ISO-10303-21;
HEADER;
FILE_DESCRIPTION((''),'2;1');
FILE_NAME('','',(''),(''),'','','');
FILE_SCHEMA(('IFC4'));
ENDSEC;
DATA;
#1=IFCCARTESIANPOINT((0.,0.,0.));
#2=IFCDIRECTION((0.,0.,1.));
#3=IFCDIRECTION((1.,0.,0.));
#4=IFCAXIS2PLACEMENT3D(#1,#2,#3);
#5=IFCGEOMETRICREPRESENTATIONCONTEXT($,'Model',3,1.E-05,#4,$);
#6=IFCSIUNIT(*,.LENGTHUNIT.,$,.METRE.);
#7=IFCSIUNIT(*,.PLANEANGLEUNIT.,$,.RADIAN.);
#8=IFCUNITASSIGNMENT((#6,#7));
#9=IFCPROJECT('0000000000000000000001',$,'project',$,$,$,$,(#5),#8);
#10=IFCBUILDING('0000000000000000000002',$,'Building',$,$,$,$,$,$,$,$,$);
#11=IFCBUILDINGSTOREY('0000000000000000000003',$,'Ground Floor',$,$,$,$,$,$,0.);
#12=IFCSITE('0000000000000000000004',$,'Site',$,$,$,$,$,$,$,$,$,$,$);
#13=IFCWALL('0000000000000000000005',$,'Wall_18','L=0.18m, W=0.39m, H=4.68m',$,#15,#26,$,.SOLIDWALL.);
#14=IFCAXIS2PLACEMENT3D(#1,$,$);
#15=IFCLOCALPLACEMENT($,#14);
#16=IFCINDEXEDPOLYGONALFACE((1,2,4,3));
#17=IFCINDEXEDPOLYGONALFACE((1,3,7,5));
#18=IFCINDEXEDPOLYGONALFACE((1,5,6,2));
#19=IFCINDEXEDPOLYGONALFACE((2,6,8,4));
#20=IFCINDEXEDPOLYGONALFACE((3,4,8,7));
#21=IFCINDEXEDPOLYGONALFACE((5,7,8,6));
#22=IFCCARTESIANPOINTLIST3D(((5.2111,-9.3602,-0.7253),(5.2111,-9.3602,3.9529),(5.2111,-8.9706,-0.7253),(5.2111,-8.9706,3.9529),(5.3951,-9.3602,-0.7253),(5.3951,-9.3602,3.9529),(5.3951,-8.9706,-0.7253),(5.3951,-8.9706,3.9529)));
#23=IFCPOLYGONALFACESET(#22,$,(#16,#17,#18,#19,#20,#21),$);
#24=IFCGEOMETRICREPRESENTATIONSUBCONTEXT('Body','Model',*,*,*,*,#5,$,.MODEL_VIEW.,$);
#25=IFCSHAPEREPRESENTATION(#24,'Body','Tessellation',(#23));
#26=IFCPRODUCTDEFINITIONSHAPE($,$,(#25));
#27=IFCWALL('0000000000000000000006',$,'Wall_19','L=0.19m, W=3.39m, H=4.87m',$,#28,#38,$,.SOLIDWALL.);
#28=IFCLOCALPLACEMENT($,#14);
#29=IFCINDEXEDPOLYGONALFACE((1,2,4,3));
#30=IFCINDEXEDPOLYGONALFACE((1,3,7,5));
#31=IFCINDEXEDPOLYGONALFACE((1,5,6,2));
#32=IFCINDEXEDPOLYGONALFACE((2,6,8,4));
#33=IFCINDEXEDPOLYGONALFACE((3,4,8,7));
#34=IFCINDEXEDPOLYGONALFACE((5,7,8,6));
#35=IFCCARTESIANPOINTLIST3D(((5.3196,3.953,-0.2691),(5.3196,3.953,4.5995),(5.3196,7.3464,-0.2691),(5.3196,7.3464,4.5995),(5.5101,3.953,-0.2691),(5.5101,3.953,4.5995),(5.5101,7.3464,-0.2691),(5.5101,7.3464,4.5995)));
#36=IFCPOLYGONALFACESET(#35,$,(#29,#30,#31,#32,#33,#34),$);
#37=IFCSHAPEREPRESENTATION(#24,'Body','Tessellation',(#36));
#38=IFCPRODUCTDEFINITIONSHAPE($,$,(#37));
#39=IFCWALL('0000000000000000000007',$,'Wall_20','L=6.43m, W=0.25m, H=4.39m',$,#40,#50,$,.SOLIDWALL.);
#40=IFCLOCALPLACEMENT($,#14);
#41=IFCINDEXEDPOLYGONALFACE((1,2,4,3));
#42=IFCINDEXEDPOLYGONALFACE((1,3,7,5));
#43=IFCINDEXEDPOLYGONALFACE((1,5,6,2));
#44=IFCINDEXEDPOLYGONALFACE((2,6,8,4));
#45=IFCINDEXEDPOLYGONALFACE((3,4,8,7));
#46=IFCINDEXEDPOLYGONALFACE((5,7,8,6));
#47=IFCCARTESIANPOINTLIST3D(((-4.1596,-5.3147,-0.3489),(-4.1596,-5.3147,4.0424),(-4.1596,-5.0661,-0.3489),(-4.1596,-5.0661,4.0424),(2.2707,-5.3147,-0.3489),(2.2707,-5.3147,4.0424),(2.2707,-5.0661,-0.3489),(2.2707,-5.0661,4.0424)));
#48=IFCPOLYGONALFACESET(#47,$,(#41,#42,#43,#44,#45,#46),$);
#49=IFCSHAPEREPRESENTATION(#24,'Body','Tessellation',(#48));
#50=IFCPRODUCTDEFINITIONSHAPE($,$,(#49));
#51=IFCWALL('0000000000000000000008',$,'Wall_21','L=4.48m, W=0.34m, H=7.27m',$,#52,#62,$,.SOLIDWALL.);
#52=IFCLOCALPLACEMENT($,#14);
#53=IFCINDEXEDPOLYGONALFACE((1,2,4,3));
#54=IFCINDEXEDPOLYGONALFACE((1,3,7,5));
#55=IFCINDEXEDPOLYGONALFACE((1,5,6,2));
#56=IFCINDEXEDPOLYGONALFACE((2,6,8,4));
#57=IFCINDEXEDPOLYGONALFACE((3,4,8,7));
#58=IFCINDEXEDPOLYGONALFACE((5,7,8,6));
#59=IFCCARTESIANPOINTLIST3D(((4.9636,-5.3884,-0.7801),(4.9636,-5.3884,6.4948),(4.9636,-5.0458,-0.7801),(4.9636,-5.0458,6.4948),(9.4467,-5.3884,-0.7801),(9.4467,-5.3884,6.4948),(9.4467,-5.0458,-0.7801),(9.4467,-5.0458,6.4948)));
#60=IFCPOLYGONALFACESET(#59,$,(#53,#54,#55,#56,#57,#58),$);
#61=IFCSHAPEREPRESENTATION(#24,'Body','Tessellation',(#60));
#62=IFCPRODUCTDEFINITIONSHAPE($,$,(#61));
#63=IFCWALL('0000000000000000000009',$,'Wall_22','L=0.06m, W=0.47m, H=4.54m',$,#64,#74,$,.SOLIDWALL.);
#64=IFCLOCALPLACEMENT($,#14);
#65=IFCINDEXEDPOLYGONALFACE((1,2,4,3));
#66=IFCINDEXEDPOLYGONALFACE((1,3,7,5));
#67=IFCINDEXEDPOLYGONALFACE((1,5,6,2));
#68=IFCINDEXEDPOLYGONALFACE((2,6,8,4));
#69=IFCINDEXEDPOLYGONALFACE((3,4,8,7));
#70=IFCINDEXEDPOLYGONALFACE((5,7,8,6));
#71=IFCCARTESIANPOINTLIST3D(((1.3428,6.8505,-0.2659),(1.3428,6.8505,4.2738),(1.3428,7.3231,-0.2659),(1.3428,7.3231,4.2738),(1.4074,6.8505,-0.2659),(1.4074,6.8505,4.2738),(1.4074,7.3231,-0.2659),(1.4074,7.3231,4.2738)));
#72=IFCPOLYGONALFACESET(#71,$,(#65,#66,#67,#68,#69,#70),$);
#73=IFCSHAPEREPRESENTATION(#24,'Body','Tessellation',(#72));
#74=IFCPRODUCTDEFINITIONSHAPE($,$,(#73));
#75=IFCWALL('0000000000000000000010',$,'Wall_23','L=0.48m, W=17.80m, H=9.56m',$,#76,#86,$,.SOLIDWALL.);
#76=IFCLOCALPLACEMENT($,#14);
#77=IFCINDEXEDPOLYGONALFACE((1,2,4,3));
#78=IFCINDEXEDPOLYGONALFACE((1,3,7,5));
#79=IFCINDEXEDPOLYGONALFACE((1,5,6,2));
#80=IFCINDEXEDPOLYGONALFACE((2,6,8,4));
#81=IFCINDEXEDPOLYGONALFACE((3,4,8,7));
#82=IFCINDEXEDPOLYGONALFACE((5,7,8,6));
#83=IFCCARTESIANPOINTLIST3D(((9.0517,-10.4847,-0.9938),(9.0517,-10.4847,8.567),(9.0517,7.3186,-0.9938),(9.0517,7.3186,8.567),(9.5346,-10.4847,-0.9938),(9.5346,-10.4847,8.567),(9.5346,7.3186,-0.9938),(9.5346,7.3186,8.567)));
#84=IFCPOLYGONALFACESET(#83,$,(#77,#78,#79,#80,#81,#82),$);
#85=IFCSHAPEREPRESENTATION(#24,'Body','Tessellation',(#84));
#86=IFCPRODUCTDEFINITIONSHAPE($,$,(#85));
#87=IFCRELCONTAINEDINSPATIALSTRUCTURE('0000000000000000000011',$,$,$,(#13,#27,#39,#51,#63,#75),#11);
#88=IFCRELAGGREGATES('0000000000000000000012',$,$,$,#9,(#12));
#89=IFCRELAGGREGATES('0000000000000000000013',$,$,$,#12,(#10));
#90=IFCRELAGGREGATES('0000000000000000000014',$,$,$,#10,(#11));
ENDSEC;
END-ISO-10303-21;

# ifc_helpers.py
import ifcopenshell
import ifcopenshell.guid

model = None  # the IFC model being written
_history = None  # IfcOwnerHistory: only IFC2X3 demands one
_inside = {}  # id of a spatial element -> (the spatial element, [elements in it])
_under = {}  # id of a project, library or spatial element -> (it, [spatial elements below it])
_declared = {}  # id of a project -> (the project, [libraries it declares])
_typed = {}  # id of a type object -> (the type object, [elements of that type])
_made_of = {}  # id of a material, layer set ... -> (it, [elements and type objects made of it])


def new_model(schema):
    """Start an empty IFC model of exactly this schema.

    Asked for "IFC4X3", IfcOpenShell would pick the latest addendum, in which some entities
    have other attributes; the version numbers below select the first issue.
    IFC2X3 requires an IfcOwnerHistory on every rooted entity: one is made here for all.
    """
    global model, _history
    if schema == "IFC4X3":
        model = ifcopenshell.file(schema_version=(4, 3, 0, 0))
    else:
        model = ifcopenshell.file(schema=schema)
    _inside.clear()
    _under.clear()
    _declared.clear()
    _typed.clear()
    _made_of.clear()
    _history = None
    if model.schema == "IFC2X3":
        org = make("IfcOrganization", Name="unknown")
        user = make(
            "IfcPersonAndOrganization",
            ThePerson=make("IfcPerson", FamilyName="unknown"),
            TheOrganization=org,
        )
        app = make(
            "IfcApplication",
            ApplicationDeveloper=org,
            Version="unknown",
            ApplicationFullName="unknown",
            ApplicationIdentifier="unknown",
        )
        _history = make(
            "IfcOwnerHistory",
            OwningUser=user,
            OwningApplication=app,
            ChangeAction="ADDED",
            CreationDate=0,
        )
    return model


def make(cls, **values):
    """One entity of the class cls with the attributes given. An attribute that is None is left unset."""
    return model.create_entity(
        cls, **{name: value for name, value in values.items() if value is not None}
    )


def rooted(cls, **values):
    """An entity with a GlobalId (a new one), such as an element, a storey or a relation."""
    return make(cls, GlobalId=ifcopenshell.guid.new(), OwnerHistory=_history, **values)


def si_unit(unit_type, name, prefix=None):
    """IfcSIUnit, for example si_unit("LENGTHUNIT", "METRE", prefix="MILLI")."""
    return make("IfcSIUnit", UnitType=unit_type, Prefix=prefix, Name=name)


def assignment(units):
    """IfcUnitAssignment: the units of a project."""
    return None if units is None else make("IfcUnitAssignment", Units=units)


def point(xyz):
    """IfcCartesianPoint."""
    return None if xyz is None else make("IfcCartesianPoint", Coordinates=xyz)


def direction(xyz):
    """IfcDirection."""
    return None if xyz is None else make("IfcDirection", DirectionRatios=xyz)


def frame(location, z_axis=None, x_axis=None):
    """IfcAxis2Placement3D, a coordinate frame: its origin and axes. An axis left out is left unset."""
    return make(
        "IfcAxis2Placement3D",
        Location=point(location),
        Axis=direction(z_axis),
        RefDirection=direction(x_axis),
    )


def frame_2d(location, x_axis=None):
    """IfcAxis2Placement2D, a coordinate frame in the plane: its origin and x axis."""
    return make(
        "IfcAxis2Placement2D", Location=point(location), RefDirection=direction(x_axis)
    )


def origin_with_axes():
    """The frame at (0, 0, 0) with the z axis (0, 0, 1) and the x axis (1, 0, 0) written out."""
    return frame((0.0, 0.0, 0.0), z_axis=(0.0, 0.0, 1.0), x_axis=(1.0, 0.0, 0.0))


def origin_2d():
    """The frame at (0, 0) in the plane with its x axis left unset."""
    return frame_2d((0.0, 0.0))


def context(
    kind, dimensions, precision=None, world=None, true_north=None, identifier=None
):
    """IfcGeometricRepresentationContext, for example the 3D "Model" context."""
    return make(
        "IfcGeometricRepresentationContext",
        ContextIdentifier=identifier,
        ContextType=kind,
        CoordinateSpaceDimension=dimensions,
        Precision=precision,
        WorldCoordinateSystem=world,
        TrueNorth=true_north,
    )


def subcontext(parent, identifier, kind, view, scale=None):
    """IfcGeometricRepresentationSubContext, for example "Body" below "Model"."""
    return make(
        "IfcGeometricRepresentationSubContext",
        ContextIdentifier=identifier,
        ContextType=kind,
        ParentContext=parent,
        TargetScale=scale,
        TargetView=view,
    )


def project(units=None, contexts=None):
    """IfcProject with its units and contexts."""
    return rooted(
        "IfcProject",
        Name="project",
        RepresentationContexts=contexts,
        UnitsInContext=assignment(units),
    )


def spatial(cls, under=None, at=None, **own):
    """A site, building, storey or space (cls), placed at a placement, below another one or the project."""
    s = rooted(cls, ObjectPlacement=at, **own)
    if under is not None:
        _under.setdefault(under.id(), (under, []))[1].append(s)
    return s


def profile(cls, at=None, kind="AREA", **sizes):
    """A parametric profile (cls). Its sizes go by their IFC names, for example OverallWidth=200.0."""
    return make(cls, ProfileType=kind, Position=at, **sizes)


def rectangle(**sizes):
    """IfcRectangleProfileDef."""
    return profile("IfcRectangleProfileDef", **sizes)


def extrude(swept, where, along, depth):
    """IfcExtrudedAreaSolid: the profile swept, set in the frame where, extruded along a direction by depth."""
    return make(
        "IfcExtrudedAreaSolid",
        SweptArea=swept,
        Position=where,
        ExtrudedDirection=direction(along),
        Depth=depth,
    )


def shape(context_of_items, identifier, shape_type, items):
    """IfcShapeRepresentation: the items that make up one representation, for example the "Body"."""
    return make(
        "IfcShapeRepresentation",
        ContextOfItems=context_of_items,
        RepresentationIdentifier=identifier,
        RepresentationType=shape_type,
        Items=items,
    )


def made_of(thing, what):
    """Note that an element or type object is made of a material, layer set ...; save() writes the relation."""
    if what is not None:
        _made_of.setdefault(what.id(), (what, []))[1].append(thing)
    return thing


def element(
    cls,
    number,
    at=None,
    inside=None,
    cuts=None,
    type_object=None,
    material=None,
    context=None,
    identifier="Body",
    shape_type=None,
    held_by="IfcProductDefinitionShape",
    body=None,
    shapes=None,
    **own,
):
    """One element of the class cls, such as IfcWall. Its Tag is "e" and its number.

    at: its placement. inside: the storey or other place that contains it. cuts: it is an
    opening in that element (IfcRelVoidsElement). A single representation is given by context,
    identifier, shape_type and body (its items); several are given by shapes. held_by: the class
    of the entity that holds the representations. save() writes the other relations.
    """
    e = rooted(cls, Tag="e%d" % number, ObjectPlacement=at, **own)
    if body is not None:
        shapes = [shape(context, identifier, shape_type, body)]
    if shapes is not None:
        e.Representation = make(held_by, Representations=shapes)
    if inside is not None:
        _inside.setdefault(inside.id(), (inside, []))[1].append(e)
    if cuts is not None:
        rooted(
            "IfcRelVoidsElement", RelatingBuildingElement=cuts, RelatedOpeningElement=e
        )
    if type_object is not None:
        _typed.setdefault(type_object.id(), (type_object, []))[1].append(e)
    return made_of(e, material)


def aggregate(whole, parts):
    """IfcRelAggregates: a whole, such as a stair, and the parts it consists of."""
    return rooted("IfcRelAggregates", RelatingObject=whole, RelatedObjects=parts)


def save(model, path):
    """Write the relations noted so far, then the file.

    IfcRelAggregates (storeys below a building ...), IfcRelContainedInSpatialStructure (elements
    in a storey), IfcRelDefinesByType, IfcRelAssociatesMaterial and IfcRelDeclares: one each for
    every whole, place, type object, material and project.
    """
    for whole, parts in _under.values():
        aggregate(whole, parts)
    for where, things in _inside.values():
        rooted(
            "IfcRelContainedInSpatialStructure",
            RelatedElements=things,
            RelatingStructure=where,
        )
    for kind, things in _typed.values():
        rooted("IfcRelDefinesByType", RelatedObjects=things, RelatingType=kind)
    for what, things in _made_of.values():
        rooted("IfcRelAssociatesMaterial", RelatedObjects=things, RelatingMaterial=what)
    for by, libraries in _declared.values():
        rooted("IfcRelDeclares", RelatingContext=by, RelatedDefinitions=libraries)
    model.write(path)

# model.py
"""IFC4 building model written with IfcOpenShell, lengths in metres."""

from ifc_helpers import new_model, si_unit, frame, origin_with_axes, origin_2d, context, subcontext, project, spatial, rectangle, extrude, element, save


model = new_model("IFC4")

# Units and contexts
model_context = context("Model", 3, precision=1e-05, world=origin_with_axes())
body_context = subcontext(model_context, "Body", "Model", "MODEL_VIEW")
ifc_project = project(units=[si_unit("LENGTHUNIT", "METRE"), si_unit("PLANEANGLEUNIT", "RADIAN")], contexts=[model_context])

# Site, building, storey
site = spatial("IfcSite", under=ifc_project, Name="Site")
building = spatial("IfcBuilding", under=site, Name="Building")
storey = spatial("IfcBuildingStorey", under=building, Name="Ground Floor", Elevation=0.0)

# Walls
element("IfcWall", 1, inside=storey, Name="Wall_18", Description="L=0.18m, W=0.39m, H=4.68m", PredefinedType="SOLIDWALL", context=body_context, shape_type="SweptSolid", body=[
    extrude(rectangle(XDim=0.184, YDim=0.3896, at=origin_2d()), frame((5.3031, -9.1654, -0.7253), z_axis=(0.0, 0.0, 1.0), x_axis=(1.0, 0.0, 0.0)), (0.0, 0.0, 1.0), 4.6782),
])
element("IfcWall", 2, inside=storey, Name="Wall_19", Description="L=0.19m, W=3.39m, H=4.87m", PredefinedType="SOLIDWALL", context=body_context, shape_type="SweptSolid", body=[
    extrude(rectangle(XDim=0.1906, YDim=3.3933, at=origin_2d()), frame((5.4148, 5.6497, -0.2691), z_axis=(0.0, 0.0, 1.0), x_axis=(1.0, 0.0, 0.0)), (0.0, 0.0, 1.0), 4.8686),
])
element("IfcWall", 3, inside=storey, Name="Wall_20", Description="L=6.43m, W=0.25m, H=4.39m", PredefinedType="SOLIDWALL", context=body_context, shape_type="SweptSolid", body=[
    extrude(rectangle(XDim=6.4303, YDim=0.2487, at=origin_2d()), frame((-0.9445, -5.1904, -0.3489), z_axis=(0.0, 0.0, 1.0), x_axis=(1.0, 0.0, 0.0)), (0.0, 0.0, 1.0), 4.3913),
])
element("IfcWall", 4, inside=storey, Name="Wall_21", Description="L=4.48m, W=0.34m, H=7.27m", PredefinedType="SOLIDWALL", context=body_context, shape_type="SweptSolid", body=[
    extrude(rectangle(XDim=4.4831, YDim=0.3426, at=origin_2d()), frame((7.2052, -5.2171, -0.7801), z_axis=(0.0, 0.0, 1.0), x_axis=(1.0, 0.0, 0.0)), (0.0, 0.0, 1.0), 7.2749),
])
element("IfcWall", 5, inside=storey, Name="Wall_22", Description="L=0.06m, W=0.47m, H=4.54m", PredefinedType="SOLIDWALL", context=body_context, shape_type="SweptSolid", body=[
    extrude(rectangle(XDim=0.0646, YDim=0.4726, at=origin_2d()), frame((1.3751, 7.0868, -0.2659), z_axis=(0.0, 0.0, 1.0), x_axis=(1.0, 0.0, 0.0)), (0.0, 0.0, 1.0), 4.5397),
])
element("IfcWall", 6, inside=storey, Name="Wall_23", Description="L=0.48m, W=17.80m, H=9.56m", PredefinedType="SOLIDWALL", context=body_context, shape_type="SweptSolid", body=[
    extrude(rectangle(XDim=0.483, YDim=17.8033, at=origin_2d()), frame((9.2931, -1.5831, -0.9938), z_axis=(0.0, 0.0, 1.0), x_axis=(1.0, 0.0, 0.0)), (0.0, 0.0, 1.0), 9.5608),
])

save(model, "model.ifc")
